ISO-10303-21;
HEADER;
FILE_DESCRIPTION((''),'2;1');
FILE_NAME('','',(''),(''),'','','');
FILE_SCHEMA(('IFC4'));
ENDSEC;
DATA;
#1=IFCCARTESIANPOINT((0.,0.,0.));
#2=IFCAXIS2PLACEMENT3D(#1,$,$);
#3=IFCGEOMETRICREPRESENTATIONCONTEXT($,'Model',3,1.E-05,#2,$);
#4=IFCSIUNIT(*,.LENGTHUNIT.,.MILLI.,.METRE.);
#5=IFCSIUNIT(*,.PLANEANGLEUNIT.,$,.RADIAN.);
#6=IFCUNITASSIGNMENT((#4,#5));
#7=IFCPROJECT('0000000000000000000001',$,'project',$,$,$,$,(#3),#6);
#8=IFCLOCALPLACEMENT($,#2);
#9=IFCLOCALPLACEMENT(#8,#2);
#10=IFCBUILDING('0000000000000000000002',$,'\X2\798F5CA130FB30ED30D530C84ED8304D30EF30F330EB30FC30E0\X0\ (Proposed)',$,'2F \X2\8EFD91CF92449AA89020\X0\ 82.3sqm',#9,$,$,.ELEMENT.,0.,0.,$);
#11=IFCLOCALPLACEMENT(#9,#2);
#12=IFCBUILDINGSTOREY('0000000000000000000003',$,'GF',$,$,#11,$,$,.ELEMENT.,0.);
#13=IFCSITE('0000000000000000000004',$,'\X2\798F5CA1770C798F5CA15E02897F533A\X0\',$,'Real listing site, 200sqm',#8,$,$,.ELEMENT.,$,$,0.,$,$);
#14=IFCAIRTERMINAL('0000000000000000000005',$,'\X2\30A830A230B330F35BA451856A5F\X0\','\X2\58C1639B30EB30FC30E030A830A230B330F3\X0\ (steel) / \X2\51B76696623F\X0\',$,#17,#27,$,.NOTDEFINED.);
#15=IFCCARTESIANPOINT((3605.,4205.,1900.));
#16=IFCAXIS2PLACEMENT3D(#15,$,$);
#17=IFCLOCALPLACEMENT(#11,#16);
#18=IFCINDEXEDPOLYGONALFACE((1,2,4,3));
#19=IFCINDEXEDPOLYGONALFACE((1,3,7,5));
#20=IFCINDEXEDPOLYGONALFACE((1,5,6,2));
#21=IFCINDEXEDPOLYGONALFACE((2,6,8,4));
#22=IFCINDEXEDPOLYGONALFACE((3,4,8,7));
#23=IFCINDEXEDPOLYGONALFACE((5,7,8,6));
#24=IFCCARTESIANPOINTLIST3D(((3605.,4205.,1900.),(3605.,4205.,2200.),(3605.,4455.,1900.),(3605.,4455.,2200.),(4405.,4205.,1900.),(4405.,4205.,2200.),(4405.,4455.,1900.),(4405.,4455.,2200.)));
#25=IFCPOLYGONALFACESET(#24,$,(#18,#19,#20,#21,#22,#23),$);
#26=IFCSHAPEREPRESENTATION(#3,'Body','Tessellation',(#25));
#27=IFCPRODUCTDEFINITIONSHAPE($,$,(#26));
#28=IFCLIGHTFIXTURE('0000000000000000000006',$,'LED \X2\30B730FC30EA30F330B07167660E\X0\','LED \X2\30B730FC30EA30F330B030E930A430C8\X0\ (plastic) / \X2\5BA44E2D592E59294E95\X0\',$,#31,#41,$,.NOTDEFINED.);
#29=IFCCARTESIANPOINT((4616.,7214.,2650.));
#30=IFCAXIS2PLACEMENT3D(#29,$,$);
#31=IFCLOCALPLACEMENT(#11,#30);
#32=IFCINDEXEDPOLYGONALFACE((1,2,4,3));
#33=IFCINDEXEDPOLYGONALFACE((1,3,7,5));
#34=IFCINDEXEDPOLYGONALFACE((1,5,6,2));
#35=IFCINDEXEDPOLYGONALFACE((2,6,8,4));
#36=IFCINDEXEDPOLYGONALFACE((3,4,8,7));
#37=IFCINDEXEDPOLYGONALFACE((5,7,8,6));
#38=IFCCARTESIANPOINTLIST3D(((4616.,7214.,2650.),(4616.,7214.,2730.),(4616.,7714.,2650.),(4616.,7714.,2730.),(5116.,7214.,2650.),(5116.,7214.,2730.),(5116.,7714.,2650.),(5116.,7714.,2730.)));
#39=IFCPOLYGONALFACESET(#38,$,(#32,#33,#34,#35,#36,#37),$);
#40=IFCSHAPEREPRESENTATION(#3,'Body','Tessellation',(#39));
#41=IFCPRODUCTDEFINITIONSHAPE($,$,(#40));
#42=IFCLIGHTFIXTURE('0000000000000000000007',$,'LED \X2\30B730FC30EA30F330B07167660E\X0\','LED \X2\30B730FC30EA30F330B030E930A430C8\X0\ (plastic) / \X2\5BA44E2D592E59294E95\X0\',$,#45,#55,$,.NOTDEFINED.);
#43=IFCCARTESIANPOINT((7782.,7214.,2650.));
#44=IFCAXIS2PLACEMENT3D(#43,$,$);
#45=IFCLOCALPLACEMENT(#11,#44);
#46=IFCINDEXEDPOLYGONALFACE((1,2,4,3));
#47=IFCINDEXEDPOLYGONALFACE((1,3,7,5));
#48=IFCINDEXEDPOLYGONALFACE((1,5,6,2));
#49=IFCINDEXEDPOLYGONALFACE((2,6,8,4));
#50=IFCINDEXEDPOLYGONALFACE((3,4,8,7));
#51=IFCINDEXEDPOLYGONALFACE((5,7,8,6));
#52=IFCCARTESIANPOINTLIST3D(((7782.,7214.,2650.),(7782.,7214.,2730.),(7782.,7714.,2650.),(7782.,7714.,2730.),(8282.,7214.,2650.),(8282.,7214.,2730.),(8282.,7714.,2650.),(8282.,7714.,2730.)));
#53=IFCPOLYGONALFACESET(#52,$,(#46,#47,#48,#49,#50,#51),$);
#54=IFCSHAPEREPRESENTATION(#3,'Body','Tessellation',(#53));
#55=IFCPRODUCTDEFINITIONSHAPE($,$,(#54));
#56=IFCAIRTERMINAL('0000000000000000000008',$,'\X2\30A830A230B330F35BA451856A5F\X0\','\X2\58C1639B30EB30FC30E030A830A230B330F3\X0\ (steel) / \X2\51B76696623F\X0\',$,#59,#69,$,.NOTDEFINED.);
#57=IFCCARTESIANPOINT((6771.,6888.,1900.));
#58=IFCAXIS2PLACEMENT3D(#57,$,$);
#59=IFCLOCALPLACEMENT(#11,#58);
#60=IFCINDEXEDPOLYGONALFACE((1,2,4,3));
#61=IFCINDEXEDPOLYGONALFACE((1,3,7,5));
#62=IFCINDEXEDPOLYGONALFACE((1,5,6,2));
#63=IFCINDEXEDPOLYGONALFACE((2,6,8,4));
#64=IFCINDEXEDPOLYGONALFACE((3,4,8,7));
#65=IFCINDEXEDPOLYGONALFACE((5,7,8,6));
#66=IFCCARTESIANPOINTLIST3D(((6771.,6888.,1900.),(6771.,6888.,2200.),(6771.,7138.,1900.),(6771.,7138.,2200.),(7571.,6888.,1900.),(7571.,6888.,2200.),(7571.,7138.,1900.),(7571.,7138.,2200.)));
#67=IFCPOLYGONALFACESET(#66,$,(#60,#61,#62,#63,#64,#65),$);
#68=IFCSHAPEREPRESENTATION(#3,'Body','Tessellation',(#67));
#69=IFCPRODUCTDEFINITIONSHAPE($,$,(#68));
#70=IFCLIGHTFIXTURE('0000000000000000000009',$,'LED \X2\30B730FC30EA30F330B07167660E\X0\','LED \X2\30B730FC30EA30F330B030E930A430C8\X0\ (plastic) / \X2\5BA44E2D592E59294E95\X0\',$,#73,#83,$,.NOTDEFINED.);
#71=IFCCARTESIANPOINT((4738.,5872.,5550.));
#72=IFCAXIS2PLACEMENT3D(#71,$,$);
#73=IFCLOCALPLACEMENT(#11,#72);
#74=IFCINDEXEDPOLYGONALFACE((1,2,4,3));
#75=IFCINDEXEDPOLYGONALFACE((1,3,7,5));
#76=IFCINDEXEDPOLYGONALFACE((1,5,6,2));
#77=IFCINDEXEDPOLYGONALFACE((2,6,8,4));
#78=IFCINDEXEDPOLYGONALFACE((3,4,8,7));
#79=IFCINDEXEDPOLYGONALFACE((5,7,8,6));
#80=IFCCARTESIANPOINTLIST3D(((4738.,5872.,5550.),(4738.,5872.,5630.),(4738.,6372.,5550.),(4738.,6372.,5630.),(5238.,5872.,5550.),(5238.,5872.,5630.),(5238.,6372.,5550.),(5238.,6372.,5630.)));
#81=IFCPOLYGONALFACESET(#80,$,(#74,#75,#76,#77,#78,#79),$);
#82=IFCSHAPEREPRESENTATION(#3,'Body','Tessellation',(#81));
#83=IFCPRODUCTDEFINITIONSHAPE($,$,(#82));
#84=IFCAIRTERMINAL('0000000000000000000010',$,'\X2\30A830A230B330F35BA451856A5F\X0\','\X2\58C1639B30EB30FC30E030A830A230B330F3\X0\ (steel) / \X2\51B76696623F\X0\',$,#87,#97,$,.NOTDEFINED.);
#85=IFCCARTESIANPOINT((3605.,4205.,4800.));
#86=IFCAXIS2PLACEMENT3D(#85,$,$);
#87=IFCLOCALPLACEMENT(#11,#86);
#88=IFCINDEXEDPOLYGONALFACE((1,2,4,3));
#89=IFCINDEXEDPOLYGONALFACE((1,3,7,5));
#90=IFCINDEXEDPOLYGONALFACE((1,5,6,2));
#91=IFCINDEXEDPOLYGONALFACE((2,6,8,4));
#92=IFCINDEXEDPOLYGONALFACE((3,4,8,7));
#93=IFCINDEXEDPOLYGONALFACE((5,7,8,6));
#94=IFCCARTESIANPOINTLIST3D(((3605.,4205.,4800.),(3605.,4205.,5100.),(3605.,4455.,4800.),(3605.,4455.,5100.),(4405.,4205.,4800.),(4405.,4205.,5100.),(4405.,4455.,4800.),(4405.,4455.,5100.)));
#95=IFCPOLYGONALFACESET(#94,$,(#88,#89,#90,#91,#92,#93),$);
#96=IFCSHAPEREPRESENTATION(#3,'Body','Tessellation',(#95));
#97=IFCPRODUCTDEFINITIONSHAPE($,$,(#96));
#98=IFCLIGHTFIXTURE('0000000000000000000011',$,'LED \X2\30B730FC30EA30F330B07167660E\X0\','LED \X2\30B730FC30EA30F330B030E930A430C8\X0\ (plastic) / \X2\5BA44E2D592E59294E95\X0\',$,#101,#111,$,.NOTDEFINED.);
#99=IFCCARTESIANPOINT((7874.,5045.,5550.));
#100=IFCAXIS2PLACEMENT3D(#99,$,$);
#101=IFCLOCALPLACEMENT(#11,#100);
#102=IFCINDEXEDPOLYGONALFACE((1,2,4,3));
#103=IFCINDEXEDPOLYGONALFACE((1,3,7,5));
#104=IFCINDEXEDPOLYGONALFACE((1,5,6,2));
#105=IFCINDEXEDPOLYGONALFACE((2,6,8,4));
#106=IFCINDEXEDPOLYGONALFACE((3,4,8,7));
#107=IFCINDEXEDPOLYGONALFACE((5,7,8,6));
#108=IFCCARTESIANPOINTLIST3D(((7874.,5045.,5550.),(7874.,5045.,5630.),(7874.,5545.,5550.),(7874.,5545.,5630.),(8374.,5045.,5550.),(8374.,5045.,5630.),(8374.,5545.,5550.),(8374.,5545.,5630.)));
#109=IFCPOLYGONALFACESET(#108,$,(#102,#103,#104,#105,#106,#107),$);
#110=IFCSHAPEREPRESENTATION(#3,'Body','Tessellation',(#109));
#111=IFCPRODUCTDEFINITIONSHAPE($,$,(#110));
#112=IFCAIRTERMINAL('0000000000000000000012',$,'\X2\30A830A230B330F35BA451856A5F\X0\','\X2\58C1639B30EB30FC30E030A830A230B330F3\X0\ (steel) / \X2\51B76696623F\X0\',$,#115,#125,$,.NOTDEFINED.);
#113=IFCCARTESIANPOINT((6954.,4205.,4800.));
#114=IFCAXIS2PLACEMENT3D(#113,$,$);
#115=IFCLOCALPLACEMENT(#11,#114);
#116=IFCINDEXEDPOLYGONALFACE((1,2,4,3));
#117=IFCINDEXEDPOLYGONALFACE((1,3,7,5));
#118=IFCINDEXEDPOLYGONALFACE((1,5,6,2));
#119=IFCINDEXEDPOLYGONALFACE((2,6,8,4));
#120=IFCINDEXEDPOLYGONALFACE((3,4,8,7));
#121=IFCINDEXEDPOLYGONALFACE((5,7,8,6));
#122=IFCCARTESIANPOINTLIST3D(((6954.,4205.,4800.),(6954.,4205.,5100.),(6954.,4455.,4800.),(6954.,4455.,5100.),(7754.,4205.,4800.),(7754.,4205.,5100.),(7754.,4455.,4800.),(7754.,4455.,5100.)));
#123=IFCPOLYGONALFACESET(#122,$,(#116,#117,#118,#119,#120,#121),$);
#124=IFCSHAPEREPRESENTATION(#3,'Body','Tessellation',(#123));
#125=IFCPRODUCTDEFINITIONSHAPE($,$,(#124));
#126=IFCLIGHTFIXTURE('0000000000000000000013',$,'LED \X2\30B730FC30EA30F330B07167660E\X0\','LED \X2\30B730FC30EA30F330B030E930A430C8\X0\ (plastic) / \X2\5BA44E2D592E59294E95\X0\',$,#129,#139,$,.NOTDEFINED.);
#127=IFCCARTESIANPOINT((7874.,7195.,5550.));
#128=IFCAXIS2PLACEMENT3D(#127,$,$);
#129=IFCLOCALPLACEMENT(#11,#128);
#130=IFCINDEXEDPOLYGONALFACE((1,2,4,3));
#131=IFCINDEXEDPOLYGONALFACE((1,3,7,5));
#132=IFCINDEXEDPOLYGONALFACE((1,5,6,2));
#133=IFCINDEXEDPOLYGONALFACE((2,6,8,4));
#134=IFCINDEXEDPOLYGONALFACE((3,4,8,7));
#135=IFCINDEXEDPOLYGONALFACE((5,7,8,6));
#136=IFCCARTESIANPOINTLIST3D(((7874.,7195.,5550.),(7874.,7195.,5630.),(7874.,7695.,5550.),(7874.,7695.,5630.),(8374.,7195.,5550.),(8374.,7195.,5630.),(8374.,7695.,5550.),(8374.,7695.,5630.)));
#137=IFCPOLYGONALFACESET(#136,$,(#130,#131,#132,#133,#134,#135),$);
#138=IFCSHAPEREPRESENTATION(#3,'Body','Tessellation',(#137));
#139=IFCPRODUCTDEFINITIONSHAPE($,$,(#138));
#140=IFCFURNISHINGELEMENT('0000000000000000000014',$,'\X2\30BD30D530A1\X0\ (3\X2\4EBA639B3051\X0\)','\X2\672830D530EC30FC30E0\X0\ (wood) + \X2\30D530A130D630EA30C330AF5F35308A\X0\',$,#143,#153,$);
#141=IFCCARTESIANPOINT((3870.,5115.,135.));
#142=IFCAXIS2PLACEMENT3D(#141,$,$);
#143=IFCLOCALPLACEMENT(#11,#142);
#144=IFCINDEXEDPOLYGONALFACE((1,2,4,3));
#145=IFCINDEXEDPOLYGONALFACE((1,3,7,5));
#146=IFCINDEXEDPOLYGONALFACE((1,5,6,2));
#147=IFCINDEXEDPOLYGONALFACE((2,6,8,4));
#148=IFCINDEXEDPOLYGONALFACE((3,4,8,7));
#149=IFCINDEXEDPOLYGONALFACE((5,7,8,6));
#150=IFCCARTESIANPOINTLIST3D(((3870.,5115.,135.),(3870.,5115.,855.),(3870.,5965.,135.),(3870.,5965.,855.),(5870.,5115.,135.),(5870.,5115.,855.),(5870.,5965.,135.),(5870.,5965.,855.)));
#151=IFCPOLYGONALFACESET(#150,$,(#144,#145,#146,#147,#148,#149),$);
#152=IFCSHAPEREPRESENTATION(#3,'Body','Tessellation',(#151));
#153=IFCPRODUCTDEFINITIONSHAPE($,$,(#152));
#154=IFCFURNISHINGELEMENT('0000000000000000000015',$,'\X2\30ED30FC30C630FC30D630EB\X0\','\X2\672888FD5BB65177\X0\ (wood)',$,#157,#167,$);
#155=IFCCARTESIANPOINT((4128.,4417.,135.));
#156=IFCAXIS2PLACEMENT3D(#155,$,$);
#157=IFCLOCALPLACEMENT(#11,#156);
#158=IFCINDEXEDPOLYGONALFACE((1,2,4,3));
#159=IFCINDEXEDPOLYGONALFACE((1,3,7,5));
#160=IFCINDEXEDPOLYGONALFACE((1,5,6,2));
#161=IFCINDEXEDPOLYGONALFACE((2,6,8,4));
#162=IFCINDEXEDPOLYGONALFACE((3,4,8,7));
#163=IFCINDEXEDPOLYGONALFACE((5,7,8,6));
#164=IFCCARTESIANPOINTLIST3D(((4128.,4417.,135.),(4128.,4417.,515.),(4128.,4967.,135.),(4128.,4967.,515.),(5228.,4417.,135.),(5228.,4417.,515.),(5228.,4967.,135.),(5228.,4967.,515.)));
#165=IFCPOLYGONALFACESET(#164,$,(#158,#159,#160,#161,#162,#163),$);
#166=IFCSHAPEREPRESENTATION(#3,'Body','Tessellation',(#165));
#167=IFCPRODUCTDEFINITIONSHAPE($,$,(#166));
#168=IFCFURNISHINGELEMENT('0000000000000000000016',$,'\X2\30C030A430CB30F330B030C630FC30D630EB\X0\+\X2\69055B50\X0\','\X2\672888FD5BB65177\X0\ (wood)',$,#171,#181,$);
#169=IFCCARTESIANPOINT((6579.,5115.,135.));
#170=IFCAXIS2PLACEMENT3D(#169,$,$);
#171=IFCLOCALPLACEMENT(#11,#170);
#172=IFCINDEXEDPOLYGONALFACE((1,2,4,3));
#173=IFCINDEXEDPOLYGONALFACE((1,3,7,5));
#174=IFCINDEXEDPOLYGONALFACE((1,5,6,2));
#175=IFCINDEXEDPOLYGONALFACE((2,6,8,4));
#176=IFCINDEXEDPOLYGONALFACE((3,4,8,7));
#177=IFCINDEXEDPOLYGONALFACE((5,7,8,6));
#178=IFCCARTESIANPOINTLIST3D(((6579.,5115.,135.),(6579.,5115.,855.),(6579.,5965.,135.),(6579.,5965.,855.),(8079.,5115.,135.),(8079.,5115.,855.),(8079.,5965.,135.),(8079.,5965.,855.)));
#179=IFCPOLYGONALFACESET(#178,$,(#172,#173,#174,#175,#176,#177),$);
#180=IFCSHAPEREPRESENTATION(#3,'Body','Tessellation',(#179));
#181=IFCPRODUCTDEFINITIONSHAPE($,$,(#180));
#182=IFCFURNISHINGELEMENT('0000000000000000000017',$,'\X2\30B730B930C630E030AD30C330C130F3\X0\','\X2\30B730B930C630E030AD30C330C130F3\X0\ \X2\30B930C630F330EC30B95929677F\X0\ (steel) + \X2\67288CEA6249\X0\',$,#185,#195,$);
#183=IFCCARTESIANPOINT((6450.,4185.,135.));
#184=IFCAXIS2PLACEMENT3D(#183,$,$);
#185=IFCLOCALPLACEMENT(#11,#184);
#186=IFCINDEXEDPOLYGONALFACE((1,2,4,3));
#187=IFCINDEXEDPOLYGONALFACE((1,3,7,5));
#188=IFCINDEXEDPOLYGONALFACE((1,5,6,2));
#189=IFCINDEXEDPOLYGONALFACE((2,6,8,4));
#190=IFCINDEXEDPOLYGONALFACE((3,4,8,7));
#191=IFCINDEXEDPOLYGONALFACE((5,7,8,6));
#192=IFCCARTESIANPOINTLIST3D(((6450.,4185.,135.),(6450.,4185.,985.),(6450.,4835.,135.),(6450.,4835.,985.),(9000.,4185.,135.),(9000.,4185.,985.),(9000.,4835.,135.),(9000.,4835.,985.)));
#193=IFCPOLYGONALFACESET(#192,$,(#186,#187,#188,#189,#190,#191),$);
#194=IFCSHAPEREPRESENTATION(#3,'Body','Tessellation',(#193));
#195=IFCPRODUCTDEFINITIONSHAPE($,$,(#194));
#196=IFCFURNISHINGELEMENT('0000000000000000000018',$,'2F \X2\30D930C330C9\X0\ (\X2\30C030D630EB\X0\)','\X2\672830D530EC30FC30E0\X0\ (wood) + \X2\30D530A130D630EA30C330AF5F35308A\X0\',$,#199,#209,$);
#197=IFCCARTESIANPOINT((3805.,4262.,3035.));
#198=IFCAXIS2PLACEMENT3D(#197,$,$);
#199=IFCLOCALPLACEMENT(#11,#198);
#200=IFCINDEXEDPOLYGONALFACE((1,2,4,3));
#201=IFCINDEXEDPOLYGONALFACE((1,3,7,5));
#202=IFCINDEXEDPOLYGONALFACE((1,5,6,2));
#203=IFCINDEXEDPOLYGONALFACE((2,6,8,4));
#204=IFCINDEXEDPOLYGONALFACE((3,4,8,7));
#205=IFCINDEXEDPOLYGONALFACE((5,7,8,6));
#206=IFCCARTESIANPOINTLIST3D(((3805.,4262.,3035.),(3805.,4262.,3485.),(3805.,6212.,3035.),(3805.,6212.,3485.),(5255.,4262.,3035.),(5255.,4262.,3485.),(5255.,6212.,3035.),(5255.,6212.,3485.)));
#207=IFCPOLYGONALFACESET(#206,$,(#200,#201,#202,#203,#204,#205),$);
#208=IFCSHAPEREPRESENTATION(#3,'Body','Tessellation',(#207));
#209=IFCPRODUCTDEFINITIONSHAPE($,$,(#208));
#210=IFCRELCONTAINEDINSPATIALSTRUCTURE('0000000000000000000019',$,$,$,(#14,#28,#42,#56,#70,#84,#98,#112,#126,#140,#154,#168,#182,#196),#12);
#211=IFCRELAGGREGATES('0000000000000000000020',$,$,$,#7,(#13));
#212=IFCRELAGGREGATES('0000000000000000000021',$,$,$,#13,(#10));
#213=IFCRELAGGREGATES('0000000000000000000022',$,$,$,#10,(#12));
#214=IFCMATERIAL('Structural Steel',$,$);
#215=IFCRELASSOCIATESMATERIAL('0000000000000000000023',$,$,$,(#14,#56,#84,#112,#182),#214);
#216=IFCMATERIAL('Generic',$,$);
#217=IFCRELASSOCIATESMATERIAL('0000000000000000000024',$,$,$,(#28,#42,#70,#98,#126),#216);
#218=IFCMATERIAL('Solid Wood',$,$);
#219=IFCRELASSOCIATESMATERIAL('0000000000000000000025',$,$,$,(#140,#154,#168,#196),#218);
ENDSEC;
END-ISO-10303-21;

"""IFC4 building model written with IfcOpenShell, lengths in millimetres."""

from ifc_helpers import new_model, si_unit, frame, frame_2d, origin, place, context, project, spatial, rectangle, extrude, material, element, save


model = new_model("IFC4")

# Units and contexts
model_context = context("Model", 3, precision=1e-05, world=origin())
ifc_project = project(units=[si_unit("LENGTHUNIT", "METRE", prefix="MILLI"), si_unit("PLANEANGLEUNIT", "RADIAN")], contexts=[model_context])

# Site, building, storey
site_placement = place(None, origin())
site = spatial("IfcSite", under=ifc_project, at=site_placement, Name="福岡県福岡市西区", ObjectType="Real listing site, 200sqm", CompositionType="ELEMENT", RefElevation=0.0)
building_placement = place(site_placement, origin())
building = spatial("IfcBuilding", under=site, at=building_placement, Name="福岡・ロフト付きワンルーム (Proposed)", ObjectType="2F 軽量鉄骨造 82.3sqm", CompositionType="ELEMENT", ElevationOfRefHeight=0.0, ElevationOfTerrain=0.0)
storey_placement = place(building_placement, origin())
storey = spatial("IfcBuildingStorey", under=building, at=storey_placement, Name="GF", CompositionType="ELEMENT", Elevation=0.0)

# Shared definitions
ifc_material_1 = material(Name="Solid Wood")

# Shared definitions
ifc_material_2 = material(Name="Structural Steel")

# Shared definitions
ifc_material_3 = material(Name="Generic")

# Air terminal
air_terminal_1_placement = place(storey_placement, frame((3605.0, 4205.0, 1900.0)))
element("IfcAirTerminal", 1, at=air_terminal_1_placement, inside=storey, material=ifc_material_2, Name="エアコン室内機", Description="壁掛ルームエアコン (steel) / 冷暖房", PredefinedType="NOTDEFINED", context=model_context, shape_type="SweptSolid", body=[
    extrude(rectangle(XDim=800.0, YDim=250.0, at=frame_2d((400.0, 125.0))), frame((3605.0, 4205.0, 1900.0)), (0.0, 0.0, 1.0), 300.0),
])

# Light fixtures
light_fixture_1_placement = place(storey_placement, frame((4616.0, 7214.0, 2650.0)))
element("IfcLightFixture", 2, at=light_fixture_1_placement, inside=storey, material=ifc_material_3, Name="LED シーリング照明", Description="LED シーリングライト (plastic) / 室中央天井", PredefinedType="NOTDEFINED", context=model_context, shape_type="SweptSolid", body=[
    extrude(rectangle(XDim=500.0, YDim=500.0, at=frame_2d((250.0, 250.0))), frame((4616.0, 7214.0, 2650.0)), (0.0, 0.0, 1.0), 80.0),
])
light_fixture_2_placement = place(storey_placement, frame((7782.0, 7214.0, 2650.0)))
element("IfcLightFixture", 3, at=light_fixture_2_placement, inside=storey, material=ifc_material_3, Name="LED シーリング照明", Description="LED シーリングライト (plastic) / 室中央天井", PredefinedType="NOTDEFINED", context=model_context, shape_type="SweptSolid", body=[
    extrude(rectangle(XDim=500.0, YDim=500.0, at=frame_2d((250.0, 250.0))), frame((7782.0, 7214.0, 2650.0)), (0.0, 0.0, 1.0), 80.0),
])

# Air terminal
air_terminal_2_placement = place(storey_placement, frame((6771.0, 6888.0, 1900.0)))
element("IfcAirTerminal", 4, at=air_terminal_2_placement, inside=storey, material=ifc_material_2, Name="エアコン室内機", Description="壁掛ルームエアコン (steel) / 冷暖房", PredefinedType="NOTDEFINED", context=model_context, shape_type="SweptSolid", body=[
    extrude(rectangle(XDim=800.0, YDim=250.0, at=frame_2d((400.0, 125.0))), frame((6771.0, 6888.0, 1900.0)), (0.0, 0.0, 1.0), 300.0),
])

# Light fixture
light_fixture_3_placement = place(storey_placement, frame((4738.0, 5872.0, 5550.0)))
element("IfcLightFixture", 5, at=light_fixture_3_placement, inside=storey, material=ifc_material_3, Name="LED シーリング照明", Description="LED シーリングライト (plastic) / 室中央天井", PredefinedType="NOTDEFINED", context=model_context, shape_type="SweptSolid", body=[
    extrude(rectangle(XDim=500.0, YDim=500.0, at=frame_2d((250.0, 250.0))), frame((4738.0, 5872.0, 5550.0)), (0.0, 0.0, 1.0), 80.0),
])

# Air terminal
air_terminal_3_placement = place(storey_placement, frame((3605.0, 4205.0, 4800.0)))
element("IfcAirTerminal", 6, at=air_terminal_3_placement, inside=storey, material=ifc_material_2, Name="エアコン室内機", Description="壁掛ルームエアコン (steel) / 冷暖房", PredefinedType="NOTDEFINED", context=model_context, shape_type="SweptSolid", body=[
    extrude(rectangle(XDim=800.0, YDim=250.0, at=frame_2d((400.0, 125.0))), frame((3605.0, 4205.0, 4800.0)), (0.0, 0.0, 1.0), 300.0),
])

# Light fixture
light_fixture_4_placement = place(storey_placement, frame((7874.0, 5045.0, 5550.0)))
element("IfcLightFixture", 7, at=light_fixture_4_placement, inside=storey, material=ifc_material_3, Name="LED シーリング照明", Description="LED シーリングライト (plastic) / 室中央天井", PredefinedType="NOTDEFINED", context=model_context, shape_type="SweptSolid", body=[
    extrude(rectangle(XDim=500.0, YDim=500.0, at=frame_2d((250.0, 250.0))), frame((7874.0, 5045.0, 5550.0)), (0.0, 0.0, 1.0), 80.0),
])

# Air terminal
air_terminal_4_placement = place(storey_placement, frame((6954.0, 4205.0, 4800.0)))
element("IfcAirTerminal", 8, at=air_terminal_4_placement, inside=storey, material=ifc_material_2, Name="エアコン室内機", Description="壁掛ルームエアコン (steel) / 冷暖房", PredefinedType="NOTDEFINED", context=model_context, shape_type="SweptSolid", body=[
    extrude(rectangle(XDim=800.0, YDim=250.0, at=frame_2d((400.0, 125.0))), frame((6954.0, 4205.0, 4800.0)), (0.0, 0.0, 1.0), 300.0),
])

# Light fixture
light_fixture_5_placement = place(storey_placement, frame((7874.0, 7195.0, 5550.0)))
element("IfcLightFixture", 9, at=light_fixture_5_placement, inside=storey, material=ifc_material_3, Name="LED シーリング照明", Description="LED シーリングライト (plastic) / 室中央天井", PredefinedType="NOTDEFINED", context=model_context, shape_type="SweptSolid", body=[
    extrude(rectangle(XDim=500.0, YDim=500.0, at=frame_2d((250.0, 250.0))), frame((7874.0, 7195.0, 5550.0)), (0.0, 0.0, 1.0), 80.0),
])

# Furnishing elements
furnishing_1_placement = place(storey_placement, frame((3870.0, 5115.0, 135.0)))
element("IfcFurnishingElement", 10, at=furnishing_1_placement, inside=storey, material=ifc_material_1, Name="ソファ (3人掛け)", Description="木フレーム (wood) + ファブリック張り", context=model_context, shape_type="SweptSolid", body=[
    extrude(rectangle(XDim=2000.0, YDim=850.0, at=frame_2d((1000.0, 425.0))), frame((3870.0, 5115.0, 135.0)), (0.0, 0.0, 1.0), 720.0),
])
furnishing_2_placement = place(storey_placement, frame((4128.0, 4417.0, 135.0)))
element("IfcFurnishingElement", 11, at=furnishing_2_placement, inside=storey, material=ifc_material_1, Name="ローテーブル", Description="木製家具 (wood)", context=model_context, shape_type="SweptSolid", body=[
    extrude(rectangle(XDim=1100.0, YDim=550.0, at=frame_2d((550.0, 275.0))), frame((4128.0, 4417.0, 135.0)), (0.0, 0.0, 1.0), 380.0),
])
furnishing_3_placement = place(storey_placement, frame((6579.0, 5115.0, 135.0)))
element("IfcFurnishingElement", 12, at=furnishing_3_placement, inside=storey, material=ifc_material_1, Name="ダイニングテーブル+椅子", Description="木製家具 (wood)", context=model_context, shape_type="SweptSolid", body=[
    extrude(rectangle(XDim=1500.0, YDim=850.0, at=frame_2d((750.0, 425.0))), frame((6579.0, 5115.0, 135.0)), (0.0, 0.0, 1.0), 720.0),
])
furnishing_4_placement = place(storey_placement, frame((6450.0, 4185.0, 135.0)))
element("IfcFurnishingElement", 13, at=furnishing_4_placement, inside=storey, material=ifc_material_2, Name="システムキッチン", Description="システムキッチン ステンレス天板 (steel) + 木質扉", context=model_context, shape_type="SweptSolid", body=[
    extrude(rectangle(XDim=2550.0, YDim=650.0, at=frame_2d((1275.0, 325.0))), frame((6450.0, 4185.0, 135.0)), (0.0, 0.0, 1.0), 850.0),
])
furnishing_5_placement = place(storey_placement, frame((3805.0, 4262.0, 3035.0)))
element("IfcFurnishingElement", 14, at=furnishing_5_placement, inside=storey, material=ifc_material_1, Name="2F ベッド (ダブル)", Description="木フレーム (wood) + ファブリック張り", context=model_context, shape_type="SweptSolid", body=[
    extrude(rectangle(XDim=1450.0, YDim=1950.0, at=frame_2d((725.0, 975.0))), frame((3805.0, 4262.0, 3035.0)), (0.0, 0.0, 1.0), 450.0),
])

save(model, "model.ifc")
